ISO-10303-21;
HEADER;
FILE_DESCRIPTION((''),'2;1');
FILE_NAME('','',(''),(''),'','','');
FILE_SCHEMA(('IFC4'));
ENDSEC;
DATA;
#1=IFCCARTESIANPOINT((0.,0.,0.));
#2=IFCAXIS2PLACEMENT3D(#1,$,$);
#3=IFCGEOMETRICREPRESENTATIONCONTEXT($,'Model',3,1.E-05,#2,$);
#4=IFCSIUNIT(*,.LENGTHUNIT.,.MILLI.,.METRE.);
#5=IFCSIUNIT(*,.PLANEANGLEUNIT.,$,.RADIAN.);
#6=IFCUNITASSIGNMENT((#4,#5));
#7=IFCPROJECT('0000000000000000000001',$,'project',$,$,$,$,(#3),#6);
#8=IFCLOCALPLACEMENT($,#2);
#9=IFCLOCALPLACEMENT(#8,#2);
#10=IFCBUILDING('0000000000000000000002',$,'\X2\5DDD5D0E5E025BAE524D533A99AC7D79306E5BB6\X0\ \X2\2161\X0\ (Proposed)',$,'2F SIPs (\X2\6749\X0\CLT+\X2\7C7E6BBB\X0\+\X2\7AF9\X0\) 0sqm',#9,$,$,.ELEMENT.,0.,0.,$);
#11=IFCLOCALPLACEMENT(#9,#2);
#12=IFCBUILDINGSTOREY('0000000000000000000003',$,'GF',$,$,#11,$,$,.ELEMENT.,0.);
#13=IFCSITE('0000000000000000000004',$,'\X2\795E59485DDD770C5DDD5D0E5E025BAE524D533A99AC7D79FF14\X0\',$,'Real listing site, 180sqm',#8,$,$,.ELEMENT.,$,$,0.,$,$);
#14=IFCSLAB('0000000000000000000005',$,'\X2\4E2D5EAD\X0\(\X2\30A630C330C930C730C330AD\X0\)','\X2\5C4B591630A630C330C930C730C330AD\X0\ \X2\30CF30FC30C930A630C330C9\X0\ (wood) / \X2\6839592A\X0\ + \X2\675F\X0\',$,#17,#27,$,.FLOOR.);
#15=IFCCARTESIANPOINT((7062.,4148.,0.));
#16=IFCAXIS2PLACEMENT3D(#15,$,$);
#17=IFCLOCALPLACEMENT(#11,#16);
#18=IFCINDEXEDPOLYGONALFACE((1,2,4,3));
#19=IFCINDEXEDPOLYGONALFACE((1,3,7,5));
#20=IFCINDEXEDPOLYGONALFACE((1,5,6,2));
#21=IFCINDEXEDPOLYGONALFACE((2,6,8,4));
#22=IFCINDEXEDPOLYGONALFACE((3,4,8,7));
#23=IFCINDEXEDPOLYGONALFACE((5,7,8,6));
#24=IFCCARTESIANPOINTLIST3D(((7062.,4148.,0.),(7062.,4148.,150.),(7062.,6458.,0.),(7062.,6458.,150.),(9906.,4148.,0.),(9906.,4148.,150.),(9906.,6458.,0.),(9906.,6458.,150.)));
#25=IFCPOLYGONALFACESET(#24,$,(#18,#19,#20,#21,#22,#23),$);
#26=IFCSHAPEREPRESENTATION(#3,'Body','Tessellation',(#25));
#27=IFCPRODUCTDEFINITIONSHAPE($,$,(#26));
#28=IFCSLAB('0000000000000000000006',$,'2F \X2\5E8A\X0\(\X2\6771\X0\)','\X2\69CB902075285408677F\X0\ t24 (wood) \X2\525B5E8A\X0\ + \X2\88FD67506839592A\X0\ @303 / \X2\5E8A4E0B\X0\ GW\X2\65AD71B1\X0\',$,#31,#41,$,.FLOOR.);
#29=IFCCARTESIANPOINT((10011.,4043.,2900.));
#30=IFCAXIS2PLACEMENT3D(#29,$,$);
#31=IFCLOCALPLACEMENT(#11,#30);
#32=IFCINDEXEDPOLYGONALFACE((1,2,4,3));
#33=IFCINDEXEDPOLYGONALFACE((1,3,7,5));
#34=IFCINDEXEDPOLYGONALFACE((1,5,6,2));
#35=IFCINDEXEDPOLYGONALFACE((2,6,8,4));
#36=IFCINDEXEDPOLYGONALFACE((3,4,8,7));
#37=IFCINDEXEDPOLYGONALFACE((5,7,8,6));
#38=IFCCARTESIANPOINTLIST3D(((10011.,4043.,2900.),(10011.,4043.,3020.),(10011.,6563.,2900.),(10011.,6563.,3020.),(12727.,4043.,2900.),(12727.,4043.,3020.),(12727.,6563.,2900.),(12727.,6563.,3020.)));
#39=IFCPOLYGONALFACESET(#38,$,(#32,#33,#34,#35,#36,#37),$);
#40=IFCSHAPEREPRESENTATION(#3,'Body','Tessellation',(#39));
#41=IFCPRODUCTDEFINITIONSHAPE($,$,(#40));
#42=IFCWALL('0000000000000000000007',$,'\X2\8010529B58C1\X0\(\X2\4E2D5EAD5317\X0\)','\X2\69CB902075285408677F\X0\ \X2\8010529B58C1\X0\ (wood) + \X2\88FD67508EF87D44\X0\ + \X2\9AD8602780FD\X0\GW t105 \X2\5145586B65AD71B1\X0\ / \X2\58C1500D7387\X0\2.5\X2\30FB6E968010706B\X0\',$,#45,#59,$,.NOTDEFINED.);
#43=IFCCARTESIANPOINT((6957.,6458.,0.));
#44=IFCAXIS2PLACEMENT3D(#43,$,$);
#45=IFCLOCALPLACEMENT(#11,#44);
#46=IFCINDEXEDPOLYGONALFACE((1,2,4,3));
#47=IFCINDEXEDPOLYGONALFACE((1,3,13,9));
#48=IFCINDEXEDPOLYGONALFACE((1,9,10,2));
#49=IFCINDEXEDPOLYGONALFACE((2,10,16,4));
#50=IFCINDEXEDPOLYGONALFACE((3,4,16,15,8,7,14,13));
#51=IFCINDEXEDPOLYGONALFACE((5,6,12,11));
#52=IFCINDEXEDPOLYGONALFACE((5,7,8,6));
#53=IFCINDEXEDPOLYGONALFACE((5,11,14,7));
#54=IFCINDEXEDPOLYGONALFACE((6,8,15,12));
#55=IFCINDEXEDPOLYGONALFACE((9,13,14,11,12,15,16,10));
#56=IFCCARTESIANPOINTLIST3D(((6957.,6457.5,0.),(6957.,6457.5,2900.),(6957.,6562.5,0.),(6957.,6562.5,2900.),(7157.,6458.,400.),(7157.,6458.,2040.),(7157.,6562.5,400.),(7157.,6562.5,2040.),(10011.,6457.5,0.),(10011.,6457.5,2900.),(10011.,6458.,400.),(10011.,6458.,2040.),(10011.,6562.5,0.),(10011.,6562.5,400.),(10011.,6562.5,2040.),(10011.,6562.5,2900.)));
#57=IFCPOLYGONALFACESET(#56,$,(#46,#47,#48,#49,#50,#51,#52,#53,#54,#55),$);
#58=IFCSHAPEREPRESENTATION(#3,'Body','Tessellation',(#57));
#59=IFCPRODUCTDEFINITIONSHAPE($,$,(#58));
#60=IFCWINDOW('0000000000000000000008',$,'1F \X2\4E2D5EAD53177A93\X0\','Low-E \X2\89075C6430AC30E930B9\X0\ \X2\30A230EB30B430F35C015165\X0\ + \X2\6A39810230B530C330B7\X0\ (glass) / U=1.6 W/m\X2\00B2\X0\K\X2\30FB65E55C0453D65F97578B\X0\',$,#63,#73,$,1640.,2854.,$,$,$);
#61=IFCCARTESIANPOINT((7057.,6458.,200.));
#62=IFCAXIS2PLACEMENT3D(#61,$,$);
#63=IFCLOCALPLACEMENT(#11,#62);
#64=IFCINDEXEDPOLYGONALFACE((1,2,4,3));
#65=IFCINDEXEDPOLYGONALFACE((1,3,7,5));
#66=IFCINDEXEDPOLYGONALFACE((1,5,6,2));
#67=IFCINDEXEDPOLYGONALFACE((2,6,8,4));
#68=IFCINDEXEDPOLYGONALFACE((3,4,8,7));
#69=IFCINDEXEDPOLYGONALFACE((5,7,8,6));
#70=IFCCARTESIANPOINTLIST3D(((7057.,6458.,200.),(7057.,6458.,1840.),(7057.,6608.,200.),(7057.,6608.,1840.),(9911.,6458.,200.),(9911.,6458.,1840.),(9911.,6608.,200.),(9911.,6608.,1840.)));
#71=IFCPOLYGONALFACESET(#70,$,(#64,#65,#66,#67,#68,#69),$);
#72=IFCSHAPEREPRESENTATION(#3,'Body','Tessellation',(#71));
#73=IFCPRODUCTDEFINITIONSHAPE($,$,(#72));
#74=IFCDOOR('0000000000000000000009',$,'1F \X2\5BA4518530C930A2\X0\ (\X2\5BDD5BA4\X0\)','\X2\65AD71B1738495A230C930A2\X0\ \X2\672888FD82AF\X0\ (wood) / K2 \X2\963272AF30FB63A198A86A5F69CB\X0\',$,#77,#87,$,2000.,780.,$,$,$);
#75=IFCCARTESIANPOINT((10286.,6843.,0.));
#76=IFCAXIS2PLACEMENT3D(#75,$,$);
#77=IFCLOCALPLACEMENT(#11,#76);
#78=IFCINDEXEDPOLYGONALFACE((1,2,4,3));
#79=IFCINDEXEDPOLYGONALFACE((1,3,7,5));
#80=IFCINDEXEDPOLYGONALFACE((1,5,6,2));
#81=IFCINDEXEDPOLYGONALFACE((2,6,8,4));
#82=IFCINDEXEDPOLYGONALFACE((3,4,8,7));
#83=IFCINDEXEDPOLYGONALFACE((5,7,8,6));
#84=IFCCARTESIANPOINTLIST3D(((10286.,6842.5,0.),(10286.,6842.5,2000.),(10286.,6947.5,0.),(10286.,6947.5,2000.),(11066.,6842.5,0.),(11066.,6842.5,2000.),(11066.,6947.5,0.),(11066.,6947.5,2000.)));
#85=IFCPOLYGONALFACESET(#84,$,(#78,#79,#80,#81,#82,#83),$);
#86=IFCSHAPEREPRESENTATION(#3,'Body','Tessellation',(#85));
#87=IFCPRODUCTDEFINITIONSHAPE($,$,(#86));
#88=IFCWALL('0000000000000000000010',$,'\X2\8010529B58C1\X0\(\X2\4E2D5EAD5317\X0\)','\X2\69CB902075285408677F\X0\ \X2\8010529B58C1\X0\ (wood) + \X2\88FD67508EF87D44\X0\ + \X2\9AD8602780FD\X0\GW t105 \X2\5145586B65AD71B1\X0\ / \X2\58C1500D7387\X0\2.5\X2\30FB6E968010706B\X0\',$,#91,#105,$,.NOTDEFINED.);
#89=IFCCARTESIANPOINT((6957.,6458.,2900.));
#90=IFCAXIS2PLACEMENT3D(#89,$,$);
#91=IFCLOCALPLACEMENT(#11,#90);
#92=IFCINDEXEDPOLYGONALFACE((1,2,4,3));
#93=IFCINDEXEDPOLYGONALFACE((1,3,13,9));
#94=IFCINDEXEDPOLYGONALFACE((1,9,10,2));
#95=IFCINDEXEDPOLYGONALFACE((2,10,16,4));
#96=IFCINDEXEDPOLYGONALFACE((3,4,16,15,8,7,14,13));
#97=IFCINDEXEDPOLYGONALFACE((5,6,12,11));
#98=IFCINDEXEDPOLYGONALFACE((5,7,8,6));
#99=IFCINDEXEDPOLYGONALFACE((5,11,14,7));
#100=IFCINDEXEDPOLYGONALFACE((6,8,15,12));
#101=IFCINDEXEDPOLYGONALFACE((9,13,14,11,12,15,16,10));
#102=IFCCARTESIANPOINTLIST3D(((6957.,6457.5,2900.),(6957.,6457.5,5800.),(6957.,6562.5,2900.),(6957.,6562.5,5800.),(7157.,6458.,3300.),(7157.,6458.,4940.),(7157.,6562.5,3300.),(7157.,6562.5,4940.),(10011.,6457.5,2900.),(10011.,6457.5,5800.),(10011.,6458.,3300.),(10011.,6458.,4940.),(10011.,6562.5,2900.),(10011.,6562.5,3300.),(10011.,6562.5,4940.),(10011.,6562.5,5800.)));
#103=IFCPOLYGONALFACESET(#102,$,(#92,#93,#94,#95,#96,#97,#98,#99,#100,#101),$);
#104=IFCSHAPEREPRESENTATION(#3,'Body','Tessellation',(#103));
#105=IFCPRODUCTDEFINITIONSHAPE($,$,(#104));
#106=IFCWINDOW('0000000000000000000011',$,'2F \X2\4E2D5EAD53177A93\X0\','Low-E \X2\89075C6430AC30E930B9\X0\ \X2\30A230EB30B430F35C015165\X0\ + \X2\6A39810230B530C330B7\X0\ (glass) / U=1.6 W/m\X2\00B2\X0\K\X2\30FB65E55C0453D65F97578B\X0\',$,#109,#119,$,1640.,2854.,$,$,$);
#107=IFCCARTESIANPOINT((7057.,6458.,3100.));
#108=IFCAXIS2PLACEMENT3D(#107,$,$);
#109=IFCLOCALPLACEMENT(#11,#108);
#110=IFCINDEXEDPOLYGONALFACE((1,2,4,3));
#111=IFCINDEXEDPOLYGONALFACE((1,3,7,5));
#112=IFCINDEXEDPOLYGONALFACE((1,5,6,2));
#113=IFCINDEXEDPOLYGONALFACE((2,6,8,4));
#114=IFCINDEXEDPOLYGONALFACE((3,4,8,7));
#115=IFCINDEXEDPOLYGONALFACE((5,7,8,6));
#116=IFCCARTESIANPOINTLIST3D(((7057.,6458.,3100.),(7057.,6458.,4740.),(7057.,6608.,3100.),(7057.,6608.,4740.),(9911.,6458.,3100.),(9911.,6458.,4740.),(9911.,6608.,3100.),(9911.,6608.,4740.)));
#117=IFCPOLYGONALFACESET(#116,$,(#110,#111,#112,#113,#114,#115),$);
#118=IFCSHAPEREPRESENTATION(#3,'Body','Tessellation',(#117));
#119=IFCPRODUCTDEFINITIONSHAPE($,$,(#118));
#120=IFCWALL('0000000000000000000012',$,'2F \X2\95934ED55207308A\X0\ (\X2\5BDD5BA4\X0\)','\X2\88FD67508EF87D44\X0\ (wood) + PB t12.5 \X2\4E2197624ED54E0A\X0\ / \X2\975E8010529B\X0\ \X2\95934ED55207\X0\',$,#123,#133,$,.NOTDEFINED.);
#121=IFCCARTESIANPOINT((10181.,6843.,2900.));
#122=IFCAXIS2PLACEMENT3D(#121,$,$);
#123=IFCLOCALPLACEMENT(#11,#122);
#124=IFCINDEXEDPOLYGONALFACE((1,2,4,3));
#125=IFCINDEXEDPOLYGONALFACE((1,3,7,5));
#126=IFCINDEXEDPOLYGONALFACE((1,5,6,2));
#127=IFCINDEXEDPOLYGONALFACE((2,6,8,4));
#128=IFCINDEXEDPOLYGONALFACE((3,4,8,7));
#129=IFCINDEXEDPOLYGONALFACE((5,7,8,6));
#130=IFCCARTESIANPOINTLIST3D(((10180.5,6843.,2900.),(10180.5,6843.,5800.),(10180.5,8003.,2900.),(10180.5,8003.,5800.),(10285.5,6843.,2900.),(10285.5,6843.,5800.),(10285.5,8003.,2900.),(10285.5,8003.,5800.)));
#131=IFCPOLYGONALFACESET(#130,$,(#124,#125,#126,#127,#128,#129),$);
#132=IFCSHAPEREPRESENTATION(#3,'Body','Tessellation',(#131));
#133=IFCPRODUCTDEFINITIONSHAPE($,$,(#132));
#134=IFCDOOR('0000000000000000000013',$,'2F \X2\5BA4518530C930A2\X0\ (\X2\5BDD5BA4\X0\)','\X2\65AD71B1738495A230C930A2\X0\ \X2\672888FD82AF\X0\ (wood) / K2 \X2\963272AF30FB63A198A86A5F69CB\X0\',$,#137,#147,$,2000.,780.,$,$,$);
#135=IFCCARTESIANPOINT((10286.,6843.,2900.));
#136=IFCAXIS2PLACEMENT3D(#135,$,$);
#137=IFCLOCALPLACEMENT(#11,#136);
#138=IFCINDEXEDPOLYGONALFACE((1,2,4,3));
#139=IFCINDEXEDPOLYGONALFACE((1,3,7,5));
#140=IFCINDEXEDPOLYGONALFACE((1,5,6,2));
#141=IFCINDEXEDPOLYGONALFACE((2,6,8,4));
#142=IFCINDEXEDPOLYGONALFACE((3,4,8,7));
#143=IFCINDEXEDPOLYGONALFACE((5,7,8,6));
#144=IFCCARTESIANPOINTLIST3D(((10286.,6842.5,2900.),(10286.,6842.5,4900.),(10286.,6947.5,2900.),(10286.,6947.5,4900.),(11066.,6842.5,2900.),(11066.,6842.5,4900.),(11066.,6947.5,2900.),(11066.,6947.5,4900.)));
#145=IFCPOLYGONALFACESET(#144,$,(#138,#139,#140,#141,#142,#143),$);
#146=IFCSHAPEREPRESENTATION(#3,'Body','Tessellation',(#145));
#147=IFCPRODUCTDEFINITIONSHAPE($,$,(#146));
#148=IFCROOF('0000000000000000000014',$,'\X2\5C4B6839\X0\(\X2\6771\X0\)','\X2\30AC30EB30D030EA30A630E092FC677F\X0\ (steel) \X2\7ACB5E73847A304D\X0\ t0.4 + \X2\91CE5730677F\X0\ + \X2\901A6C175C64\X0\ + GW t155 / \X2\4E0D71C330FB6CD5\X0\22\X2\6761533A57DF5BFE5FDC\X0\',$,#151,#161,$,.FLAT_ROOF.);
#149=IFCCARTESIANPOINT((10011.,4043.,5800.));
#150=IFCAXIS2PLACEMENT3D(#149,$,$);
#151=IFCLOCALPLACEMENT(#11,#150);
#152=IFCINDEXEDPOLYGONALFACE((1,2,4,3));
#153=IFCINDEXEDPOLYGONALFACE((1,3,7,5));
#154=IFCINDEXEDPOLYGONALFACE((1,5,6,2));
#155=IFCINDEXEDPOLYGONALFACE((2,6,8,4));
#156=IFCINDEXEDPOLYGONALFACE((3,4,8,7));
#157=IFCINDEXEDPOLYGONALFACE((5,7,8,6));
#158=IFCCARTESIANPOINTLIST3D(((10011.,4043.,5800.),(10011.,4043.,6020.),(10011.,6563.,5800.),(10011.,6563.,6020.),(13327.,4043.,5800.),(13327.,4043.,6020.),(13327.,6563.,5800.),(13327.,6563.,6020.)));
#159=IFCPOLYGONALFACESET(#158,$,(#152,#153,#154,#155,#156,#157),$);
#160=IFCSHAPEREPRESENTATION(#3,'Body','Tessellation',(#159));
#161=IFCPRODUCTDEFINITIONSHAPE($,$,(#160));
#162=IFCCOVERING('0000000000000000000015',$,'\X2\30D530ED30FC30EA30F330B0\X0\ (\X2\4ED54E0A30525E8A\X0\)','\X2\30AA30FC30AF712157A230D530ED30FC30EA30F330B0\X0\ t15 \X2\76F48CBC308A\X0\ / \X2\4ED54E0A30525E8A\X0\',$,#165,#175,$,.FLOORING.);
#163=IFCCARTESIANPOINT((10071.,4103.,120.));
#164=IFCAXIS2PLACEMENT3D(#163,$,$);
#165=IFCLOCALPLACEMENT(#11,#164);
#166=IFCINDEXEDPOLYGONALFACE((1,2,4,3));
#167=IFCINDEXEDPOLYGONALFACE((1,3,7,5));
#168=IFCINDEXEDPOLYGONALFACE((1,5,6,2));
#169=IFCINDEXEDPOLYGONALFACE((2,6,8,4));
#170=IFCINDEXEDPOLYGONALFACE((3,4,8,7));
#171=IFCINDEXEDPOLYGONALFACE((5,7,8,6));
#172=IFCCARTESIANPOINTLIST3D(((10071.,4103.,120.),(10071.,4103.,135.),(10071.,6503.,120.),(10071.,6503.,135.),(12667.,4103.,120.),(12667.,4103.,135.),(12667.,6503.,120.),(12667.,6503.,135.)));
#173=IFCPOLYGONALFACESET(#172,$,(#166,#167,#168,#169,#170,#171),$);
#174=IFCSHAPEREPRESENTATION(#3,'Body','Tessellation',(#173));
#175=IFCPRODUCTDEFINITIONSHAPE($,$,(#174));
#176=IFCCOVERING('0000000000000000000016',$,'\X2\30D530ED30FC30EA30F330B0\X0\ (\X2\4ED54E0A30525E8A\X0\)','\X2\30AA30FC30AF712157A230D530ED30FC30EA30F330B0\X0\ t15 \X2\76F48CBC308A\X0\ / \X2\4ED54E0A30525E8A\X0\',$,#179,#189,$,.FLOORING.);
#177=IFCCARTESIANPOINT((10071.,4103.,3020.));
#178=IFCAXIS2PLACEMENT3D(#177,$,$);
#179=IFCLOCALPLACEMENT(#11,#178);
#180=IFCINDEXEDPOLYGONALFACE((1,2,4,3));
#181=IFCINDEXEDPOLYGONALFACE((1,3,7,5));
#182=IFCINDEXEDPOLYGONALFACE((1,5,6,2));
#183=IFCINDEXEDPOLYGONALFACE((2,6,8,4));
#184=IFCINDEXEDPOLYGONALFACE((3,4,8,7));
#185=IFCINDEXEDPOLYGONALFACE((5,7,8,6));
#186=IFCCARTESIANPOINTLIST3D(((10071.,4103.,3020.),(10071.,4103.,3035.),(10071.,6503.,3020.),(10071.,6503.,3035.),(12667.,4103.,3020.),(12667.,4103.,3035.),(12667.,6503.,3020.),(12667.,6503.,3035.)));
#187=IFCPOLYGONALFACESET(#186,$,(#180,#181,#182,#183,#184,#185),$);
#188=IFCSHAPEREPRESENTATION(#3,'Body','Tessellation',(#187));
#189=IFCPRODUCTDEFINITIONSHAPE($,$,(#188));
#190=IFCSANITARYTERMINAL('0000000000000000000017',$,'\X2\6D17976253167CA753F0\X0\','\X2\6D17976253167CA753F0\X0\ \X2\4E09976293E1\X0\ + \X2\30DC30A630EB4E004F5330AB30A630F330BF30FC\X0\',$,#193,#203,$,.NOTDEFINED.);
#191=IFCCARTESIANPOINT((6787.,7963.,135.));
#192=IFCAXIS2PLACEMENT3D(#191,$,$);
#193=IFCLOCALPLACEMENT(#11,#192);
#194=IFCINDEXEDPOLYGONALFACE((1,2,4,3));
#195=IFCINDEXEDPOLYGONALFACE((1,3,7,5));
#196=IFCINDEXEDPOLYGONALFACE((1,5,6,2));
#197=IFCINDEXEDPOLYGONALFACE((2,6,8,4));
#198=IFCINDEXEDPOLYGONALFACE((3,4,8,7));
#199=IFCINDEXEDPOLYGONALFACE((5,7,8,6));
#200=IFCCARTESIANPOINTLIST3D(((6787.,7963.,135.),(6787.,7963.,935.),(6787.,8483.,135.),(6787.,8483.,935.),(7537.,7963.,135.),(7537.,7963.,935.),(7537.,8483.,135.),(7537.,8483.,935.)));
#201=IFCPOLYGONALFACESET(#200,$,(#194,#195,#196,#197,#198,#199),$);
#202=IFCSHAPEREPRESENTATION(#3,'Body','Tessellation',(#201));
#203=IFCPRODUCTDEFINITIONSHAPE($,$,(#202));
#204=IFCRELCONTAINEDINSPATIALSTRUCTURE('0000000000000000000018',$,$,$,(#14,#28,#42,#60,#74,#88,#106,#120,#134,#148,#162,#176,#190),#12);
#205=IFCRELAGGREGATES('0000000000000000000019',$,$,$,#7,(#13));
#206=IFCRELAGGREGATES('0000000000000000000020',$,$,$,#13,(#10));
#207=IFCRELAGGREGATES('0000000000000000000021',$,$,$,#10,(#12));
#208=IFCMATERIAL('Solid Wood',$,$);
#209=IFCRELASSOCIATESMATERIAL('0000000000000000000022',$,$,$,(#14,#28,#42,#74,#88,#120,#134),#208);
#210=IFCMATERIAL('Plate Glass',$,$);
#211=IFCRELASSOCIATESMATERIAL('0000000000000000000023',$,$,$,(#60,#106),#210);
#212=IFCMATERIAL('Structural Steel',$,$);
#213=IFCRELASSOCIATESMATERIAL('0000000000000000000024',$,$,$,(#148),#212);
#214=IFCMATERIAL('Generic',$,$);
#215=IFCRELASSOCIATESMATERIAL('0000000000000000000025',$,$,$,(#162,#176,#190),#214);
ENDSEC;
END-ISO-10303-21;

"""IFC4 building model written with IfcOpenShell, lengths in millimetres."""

from ifc_helpers import new_model, si_unit, frame, frame_2d, origin, place, context, project, spatial, rectangle, extrude, material, element, fill, save


model = new_model("IFC4")

# Units and contexts
model_context = context("Model", 3, precision=1e-05, world=origin())
ifc_project = project(units=[si_unit("LENGTHUNIT", "METRE", prefix="MILLI"), si_unit("PLANEANGLEUNIT", "RADIAN")], contexts=[model_context])

# Site, building, storey
site_placement = place(None, origin())
site = spatial("IfcSite", under=ifc_project, at=site_placement, Name="神奈川県川崎市宮前区馬絹４", ObjectType="Real listing site, 180sqm", CompositionType="ELEMENT", RefElevation=0.0)
building_placement = place(site_placement, origin())
building = spatial("IfcBuilding", under=site, at=building_placement, Name="川崎市宮前区馬絹の家 Ⅱ (Proposed)", ObjectType="2F SIPs (杉CLT+籾殻+竹) 0sqm", CompositionType="ELEMENT", ElevationOfRefHeight=0.0, ElevationOfTerrain=0.0)
storey_placement = place(building_placement, origin())
storey = spatial("IfcBuildingStorey", under=building, at=storey_placement, Name="GF", CompositionType="ELEMENT", Elevation=0.0)

# Slabs
ifc_material_1 = material(Name="Solid Wood")
slab_1_placement = place(storey_placement, frame((7062.0, 4148.0, 0.0)))
element("IfcSlab", 1, at=slab_1_placement, inside=storey, material=ifc_material_1, Name="中庭(ウッドデッキ)", Description="屋外ウッドデッキ ハードウッド (wood) / 根太 + 束", PredefinedType="FLOOR", context=model_context, shape_type="SweptSolid", body=[
    extrude(rectangle(XDim=2844.0, YDim=2310.0, at=frame_2d((1422.0, 1155.0))), frame((7062.0, 4148.0, 0.0)), (0.0, 0.0, 1.0), 150.0),
])
slab_2_placement = place(storey_placement, frame((10011.0, 4043.0, 2900.0)))
element("IfcSlab", 2, at=slab_2_placement, inside=storey, material=ifc_material_1, Name="2F 床(東)", Description="構造用合板 t24 (wood) 剛床 + 製材根太 @303 / 床下 GW断熱", PredefinedType="FLOOR", context=model_context, shape_type="SweptSolid", body=[
    extrude(rectangle(XDim=2716.0, YDim=2520.0, at=frame_2d((1358.0, 1260.0))), frame((10011.0, 4043.0, 2900.0)), (0.0, 0.0, 1.0), 120.0),
])

# Wall, opening, window
wall_1_placement = place(storey_placement, frame((6957.0, 6458.0, 0.0)))
wall_1 = element("IfcWall", 3, at=wall_1_placement, inside=storey, material=ifc_material_1, Name="耐力壁(中庭北)", Description="構造用合板 耐力壁 (wood) + 製材軸組 + 高性能GW t105 充填断熱 / 壁倍率2.5・準耐火", PredefinedType="NOTDEFINED", context=model_context, shape_type="SweptSolid", body=[
    extrude(rectangle(XDim=3054.0, YDim=105.0, at=frame_2d((1527.0, 52.0))), frame((6957.0, 6458.0, 0.0)), (0.0, 0.0, 1.0), 2900.0),
])
opening_1_placement = place(storey_placement, frame((7057.0, 6458.0, 200.0)))
opening_1 = element("IfcOpeningElement", 4, at=opening_1_placement, cuts=wall_1, PredefinedType="NOTDEFINED", context=model_context, shape_type="SweptSolid", body=[
    extrude(rectangle(XDim=2854.0, YDim=150.0, at=frame_2d((1427.0, 75.0))), frame((7057.0, 6458.0, 200.0)), (0.0, 0.0, 1.0), 1640.0),
])
ifc_material_2 = material(Name="Plate Glass")
window_1_placement = place(storey_placement, frame((7057.0, 6458.0, 200.0)))
window_1 = element("IfcWindow", 5, at=window_1_placement, inside=storey, material=ifc_material_2, Name="1F 中庭北窓", Description="Low-E 複層ガラス アルゴン封入 + 樹脂サッシ (glass) / U=1.6 W/m²K・日射取得型", OverallHeight=1640.0, OverallWidth=2854.0, context=model_context, shape_type="SweptSolid", body=[
    extrude(rectangle(XDim=2854.0, YDim=150.0, at=frame_2d((1427.0, 75.0))), frame((7057.0, 6458.0, 200.0)), (0.0, 0.0, 1.0), 1640.0),
])
fill(opening_1, window_1)

# Door
door_1_placement = place(storey_placement, frame((10286.0, 6843.0, 0.0)))
element("IfcDoor", 6, at=door_1_placement, inside=storey, material=ifc_material_1, Name="1F 室内ドア (寝室)", Description="断熱玄関ドア 木製芯 (wood) / K2 防犯・採風機構", OverallHeight=2000.0, OverallWidth=780.0, context=model_context, shape_type="SweptSolid", body=[
    extrude(rectangle(XDim=780.0, YDim=105.0, at=frame_2d((390.0, 52.0))), frame((10286.0, 6843.0, 0.0)), (0.0, 0.0, 1.0), 2000.0),
])

# Wall, opening, window
wall_2_placement = place(storey_placement, frame((6957.0, 6458.0, 2900.0)))
wall_2 = element("IfcWall", 7, at=wall_2_placement, inside=storey, material=ifc_material_1, Name="耐力壁(中庭北)", Description="構造用合板 耐力壁 (wood) + 製材軸組 + 高性能GW t105 充填断熱 / 壁倍率2.5・準耐火", PredefinedType="NOTDEFINED", context=model_context, shape_type="SweptSolid", body=[
    extrude(rectangle(XDim=3054.0, YDim=105.0, at=frame_2d((1527.0, 52.0))), frame((6957.0, 6458.0, 2900.0)), (0.0, 0.0, 1.0), 2900.0),
])
opening_2_placement = place(storey_placement, frame((7057.0, 6458.0, 3100.0)))
opening_2 = element("IfcOpeningElement", 8, at=opening_2_placement, cuts=wall_2, PredefinedType="NOTDEFINED", context=model_context, shape_type="SweptSolid", body=[
    extrude(rectangle(XDim=2854.0, YDim=150.0, at=frame_2d((1427.0, 75.0))), frame((7057.0, 6458.0, 3100.0)), (0.0, 0.0, 1.0), 1640.0),
])
window_2_placement = place(storey_placement, frame((7057.0, 6458.0, 3100.0)))
window_2 = element("IfcWindow", 9, at=window_2_placement, inside=storey, material=ifc_material_2, Name="2F 中庭北窓", Description="Low-E 複層ガラス アルゴン封入 + 樹脂サッシ (glass) / U=1.6 W/m²K・日射取得型", OverallHeight=1640.0, OverallWidth=2854.0, context=model_context, shape_type="SweptSolid", body=[
    extrude(rectangle(XDim=2854.0, YDim=150.0, at=frame_2d((1427.0, 75.0))), frame((7057.0, 6458.0, 3100.0)), (0.0, 0.0, 1.0), 1640.0),
])
fill(opening_2, window_2)

# Wall
wall_3_placement = place(storey_placement, frame((10181.0, 6843.0, 2900.0)))
element("IfcWall", 10, at=wall_3_placement, inside=storey, material=ifc_material_1, Name="2F 間仕切り (寝室)", Description="製材軸組 (wood) + PB t12.5 両面仕上 / 非耐力 間仕切", PredefinedType="NOTDEFINED", context=model_context, shape_type="SweptSolid", body=[
    extrude(rectangle(XDim=105.0, YDim=1160.0, at=frame_2d((52.0, 580.0))), frame((10181.0, 6843.0, 2900.0)), (0.0, 0.0, 1.0), 2900.0),
])

# Door
door_2_placement = place(storey_placement, frame((10286.0, 6843.0, 2900.0)))
element("IfcDoor", 11, at=door_2_placement, inside=storey, material=ifc_material_1, Name="2F 室内ドア (寝室)", Description="断熱玄関ドア 木製芯 (wood) / K2 防犯・採風機構", OverallHeight=2000.0, OverallWidth=780.0, context=model_context, shape_type="SweptSolid", body=[
    extrude(rectangle(XDim=780.0, YDim=105.0, at=frame_2d((390.0, 52.0))), frame((10286.0, 6843.0, 2900.0)), (0.0, 0.0, 1.0), 2000.0),
])

# Roof
ifc_material_3 = material(Name="Structural Steel")
for number, where, name in (
    (12, (10011.0, 4043.0, 5800.0), "屋根(東)"),
):
    element("IfcRoof", number, at=place(storey_placement, frame(where)), inside=storey, material=ifc_material_3, Name=name, Description="ガルバリウム鋼板 (steel) 立平葺き t0.4 + 野地板 + 通気層 + GW t155 / 不燃・法22条区域対応", PredefinedType="FLAT_ROOF", context=model_context, shape_type="SweptSolid", body=[
        extrude(rectangle(XDim=3316.0, YDim=2520.0, at=frame_2d((1658.0, 1260.0))), frame((10011.0, 4043.0, 5800.0)), (0.0, 0.0, 1.0), 220.0),
    ])

# Coverings
ifc_material_4 = material(Name="Generic")
covering_1_placement = place(storey_placement, frame((10071.0, 4103.0, 120.0)))
element("IfcCovering", 13, at=covering_1_placement, inside=storey, material=ifc_material_4, Name="フローリング (仕上げ床)", Description="オーク無垢フローリング t15 直貼り / 仕上げ床", PredefinedType="FLOORING", context=model_context, shape_type="SweptSolid", body=[
    extrude(rectangle(XDim=2596.0, YDim=2400.0, at=frame_2d((1298.0, 1200.0))), frame((10071.0, 4103.0, 120.0)), (0.0, 0.0, 1.0), 15.0),
])
covering_2_placement = place(storey_placement, frame((10071.0, 4103.0, 3020.0)))
element("IfcCovering", 14, at=covering_2_placement, inside=storey, material=ifc_material_4, Name="フローリング (仕上げ床)", Description="オーク無垢フローリング t15 直貼り / 仕上げ床", PredefinedType="FLOORING", context=model_context, shape_type="SweptSolid", body=[
    extrude(rectangle(XDim=2596.0, YDim=2400.0, at=frame_2d((1298.0, 1200.0))), frame((10071.0, 4103.0, 3020.0)), (0.0, 0.0, 1.0), 15.0),
])

# Sanitary terminal
sanitary_terminal_1_placement = place(storey_placement, frame((6787.0, 7963.0, 135.0)))
element("IfcSanitaryTerminal", 15, at=sanitary_terminal_1_placement, inside=storey, material=ifc_material_4, Name="洗面化粧台", Description="洗面化粧台 三面鏡 + ボウル一体カウンター", PredefinedType="NOTDEFINED", context=model_context, shape_type="SweptSolid", body=[
    extrude(rectangle(XDim=750.0, YDim=520.0, at=frame_2d((375.0, 260.0))), frame((6787.0, 7963.0, 135.0)), (0.0, 0.0, 1.0), 800.0),
])

save(model, "model.ifc")
